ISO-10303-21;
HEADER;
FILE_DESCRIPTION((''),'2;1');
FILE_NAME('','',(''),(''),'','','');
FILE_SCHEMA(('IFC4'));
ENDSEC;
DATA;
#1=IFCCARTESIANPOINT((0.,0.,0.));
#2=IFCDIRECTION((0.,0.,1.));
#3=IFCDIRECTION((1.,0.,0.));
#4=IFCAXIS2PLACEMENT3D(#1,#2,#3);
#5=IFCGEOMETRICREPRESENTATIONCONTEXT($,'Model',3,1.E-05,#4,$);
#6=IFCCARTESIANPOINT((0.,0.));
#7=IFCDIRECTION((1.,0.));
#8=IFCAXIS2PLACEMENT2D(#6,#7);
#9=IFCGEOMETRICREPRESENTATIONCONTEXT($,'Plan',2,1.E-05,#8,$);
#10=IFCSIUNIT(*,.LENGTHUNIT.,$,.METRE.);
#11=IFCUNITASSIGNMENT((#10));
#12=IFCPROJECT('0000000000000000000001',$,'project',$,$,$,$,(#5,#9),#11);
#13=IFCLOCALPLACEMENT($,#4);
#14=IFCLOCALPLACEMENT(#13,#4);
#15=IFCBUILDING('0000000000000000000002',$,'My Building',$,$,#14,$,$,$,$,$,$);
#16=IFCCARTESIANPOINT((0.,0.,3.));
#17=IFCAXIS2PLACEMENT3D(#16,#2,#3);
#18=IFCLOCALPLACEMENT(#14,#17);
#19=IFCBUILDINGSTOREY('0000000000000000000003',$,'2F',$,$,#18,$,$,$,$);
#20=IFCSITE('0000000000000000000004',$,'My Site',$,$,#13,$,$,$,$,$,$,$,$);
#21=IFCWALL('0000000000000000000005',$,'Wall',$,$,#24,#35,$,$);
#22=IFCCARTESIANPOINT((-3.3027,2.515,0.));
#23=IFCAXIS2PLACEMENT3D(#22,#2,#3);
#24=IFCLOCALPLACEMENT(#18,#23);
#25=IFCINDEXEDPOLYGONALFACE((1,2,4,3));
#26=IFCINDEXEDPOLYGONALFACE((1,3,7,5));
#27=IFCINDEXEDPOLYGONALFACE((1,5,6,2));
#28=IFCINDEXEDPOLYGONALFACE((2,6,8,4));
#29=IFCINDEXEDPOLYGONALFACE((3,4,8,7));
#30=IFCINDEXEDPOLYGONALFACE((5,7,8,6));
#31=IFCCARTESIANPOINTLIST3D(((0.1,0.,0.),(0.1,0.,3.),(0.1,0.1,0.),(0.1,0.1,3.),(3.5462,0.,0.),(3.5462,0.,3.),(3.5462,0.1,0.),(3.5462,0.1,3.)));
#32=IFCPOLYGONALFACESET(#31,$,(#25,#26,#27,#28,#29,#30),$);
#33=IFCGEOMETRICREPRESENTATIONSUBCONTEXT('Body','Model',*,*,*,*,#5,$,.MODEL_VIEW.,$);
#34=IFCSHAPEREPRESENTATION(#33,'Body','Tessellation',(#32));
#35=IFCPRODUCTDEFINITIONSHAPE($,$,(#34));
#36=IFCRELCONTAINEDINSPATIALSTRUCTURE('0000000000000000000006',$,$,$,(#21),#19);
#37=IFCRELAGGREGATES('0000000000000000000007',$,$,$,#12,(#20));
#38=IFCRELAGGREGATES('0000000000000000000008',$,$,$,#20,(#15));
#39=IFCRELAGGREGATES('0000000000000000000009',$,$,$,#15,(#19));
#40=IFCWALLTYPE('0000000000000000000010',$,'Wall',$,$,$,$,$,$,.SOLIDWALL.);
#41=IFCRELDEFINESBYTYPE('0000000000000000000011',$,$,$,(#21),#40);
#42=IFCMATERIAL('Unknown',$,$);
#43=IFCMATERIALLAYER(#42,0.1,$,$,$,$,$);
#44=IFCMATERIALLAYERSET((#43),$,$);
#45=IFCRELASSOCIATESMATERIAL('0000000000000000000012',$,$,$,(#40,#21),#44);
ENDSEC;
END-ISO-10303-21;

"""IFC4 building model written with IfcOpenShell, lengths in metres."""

from ifc_helpers import new_model, si_unit, frame, origin_with_axes, origin_2d_with_axis, place, context, subcontext, project, spatial, line, indexed_curve, outline, extrude, material, layer, layer_set, layer_usage, type_object, element, save


model = new_model("IFC4")

# Units and contexts
model_context = context("Model", 3, precision=1e-05, world=origin_with_axes())
plan_context = context("Plan", 2, precision=1e-05, world=origin_2d_with_axis())
body_context_1 = subcontext(model_context, "Body", "Model", "MODEL_VIEW")
ifc_project = project(units=[si_unit("LENGTHUNIT", "METRE")], contexts=[model_context, plan_context])

# Site, building, storey
site_placement = place(None, origin_with_axes())
site = spatial("IfcSite", under=ifc_project, at=site_placement, Name="My Site")
building_placement = place(site_placement, origin_with_axes())
building = spatial("IfcBuilding", under=site, at=building_placement, Name="My Building")
storey_placement = place(building_placement, frame((0.0, 0.0, 3.0), z_axis=(0.0, 0.0, 1.0), x_axis=(1.0, 0.0, 0.0)))
storey = spatial("IfcBuildingStorey", under=building, at=storey_placement, Name="2F")

# Shared definitions
ifc_material = material(Name="Unknown")
ifc_layer = layer(ifc_material, 0.1)
ifc_layer_set = layer_set([ifc_layer])
wall_type = type_object("IfcWallType", Name="Wall", PredefinedType="SOLIDWALL", material=ifc_layer_set)

# Wall
ifc_layer_usage_1 = layer_usage(ifc_layer_set, "AXIS2", "POSITIVE", 0.0)
wall_1_placement = place(storey_placement, frame((-3.3027, 2.515, 0.0), z_axis=(0.0, 0.0, 1.0), x_axis=(1.0, 0.0, 0.0)))
element("IfcWall", 1, at=wall_1_placement, inside=storey, type_object=wall_type, material=ifc_layer_usage_1, Name="Wall", context=body_context_1, shape_type="SweptSolid", body=[
    extrude(outline(indexed_curve([(0.1, 0.0), (0.1, 0.1), (3.5462, 0.1), (3.5462, 0.0)], segments=[line(1, 2, 3, 4, 1)])), origin_with_axes(), (0.0, 0.0, 1.0), 3.0),
])

save(model, "model.ifc")
